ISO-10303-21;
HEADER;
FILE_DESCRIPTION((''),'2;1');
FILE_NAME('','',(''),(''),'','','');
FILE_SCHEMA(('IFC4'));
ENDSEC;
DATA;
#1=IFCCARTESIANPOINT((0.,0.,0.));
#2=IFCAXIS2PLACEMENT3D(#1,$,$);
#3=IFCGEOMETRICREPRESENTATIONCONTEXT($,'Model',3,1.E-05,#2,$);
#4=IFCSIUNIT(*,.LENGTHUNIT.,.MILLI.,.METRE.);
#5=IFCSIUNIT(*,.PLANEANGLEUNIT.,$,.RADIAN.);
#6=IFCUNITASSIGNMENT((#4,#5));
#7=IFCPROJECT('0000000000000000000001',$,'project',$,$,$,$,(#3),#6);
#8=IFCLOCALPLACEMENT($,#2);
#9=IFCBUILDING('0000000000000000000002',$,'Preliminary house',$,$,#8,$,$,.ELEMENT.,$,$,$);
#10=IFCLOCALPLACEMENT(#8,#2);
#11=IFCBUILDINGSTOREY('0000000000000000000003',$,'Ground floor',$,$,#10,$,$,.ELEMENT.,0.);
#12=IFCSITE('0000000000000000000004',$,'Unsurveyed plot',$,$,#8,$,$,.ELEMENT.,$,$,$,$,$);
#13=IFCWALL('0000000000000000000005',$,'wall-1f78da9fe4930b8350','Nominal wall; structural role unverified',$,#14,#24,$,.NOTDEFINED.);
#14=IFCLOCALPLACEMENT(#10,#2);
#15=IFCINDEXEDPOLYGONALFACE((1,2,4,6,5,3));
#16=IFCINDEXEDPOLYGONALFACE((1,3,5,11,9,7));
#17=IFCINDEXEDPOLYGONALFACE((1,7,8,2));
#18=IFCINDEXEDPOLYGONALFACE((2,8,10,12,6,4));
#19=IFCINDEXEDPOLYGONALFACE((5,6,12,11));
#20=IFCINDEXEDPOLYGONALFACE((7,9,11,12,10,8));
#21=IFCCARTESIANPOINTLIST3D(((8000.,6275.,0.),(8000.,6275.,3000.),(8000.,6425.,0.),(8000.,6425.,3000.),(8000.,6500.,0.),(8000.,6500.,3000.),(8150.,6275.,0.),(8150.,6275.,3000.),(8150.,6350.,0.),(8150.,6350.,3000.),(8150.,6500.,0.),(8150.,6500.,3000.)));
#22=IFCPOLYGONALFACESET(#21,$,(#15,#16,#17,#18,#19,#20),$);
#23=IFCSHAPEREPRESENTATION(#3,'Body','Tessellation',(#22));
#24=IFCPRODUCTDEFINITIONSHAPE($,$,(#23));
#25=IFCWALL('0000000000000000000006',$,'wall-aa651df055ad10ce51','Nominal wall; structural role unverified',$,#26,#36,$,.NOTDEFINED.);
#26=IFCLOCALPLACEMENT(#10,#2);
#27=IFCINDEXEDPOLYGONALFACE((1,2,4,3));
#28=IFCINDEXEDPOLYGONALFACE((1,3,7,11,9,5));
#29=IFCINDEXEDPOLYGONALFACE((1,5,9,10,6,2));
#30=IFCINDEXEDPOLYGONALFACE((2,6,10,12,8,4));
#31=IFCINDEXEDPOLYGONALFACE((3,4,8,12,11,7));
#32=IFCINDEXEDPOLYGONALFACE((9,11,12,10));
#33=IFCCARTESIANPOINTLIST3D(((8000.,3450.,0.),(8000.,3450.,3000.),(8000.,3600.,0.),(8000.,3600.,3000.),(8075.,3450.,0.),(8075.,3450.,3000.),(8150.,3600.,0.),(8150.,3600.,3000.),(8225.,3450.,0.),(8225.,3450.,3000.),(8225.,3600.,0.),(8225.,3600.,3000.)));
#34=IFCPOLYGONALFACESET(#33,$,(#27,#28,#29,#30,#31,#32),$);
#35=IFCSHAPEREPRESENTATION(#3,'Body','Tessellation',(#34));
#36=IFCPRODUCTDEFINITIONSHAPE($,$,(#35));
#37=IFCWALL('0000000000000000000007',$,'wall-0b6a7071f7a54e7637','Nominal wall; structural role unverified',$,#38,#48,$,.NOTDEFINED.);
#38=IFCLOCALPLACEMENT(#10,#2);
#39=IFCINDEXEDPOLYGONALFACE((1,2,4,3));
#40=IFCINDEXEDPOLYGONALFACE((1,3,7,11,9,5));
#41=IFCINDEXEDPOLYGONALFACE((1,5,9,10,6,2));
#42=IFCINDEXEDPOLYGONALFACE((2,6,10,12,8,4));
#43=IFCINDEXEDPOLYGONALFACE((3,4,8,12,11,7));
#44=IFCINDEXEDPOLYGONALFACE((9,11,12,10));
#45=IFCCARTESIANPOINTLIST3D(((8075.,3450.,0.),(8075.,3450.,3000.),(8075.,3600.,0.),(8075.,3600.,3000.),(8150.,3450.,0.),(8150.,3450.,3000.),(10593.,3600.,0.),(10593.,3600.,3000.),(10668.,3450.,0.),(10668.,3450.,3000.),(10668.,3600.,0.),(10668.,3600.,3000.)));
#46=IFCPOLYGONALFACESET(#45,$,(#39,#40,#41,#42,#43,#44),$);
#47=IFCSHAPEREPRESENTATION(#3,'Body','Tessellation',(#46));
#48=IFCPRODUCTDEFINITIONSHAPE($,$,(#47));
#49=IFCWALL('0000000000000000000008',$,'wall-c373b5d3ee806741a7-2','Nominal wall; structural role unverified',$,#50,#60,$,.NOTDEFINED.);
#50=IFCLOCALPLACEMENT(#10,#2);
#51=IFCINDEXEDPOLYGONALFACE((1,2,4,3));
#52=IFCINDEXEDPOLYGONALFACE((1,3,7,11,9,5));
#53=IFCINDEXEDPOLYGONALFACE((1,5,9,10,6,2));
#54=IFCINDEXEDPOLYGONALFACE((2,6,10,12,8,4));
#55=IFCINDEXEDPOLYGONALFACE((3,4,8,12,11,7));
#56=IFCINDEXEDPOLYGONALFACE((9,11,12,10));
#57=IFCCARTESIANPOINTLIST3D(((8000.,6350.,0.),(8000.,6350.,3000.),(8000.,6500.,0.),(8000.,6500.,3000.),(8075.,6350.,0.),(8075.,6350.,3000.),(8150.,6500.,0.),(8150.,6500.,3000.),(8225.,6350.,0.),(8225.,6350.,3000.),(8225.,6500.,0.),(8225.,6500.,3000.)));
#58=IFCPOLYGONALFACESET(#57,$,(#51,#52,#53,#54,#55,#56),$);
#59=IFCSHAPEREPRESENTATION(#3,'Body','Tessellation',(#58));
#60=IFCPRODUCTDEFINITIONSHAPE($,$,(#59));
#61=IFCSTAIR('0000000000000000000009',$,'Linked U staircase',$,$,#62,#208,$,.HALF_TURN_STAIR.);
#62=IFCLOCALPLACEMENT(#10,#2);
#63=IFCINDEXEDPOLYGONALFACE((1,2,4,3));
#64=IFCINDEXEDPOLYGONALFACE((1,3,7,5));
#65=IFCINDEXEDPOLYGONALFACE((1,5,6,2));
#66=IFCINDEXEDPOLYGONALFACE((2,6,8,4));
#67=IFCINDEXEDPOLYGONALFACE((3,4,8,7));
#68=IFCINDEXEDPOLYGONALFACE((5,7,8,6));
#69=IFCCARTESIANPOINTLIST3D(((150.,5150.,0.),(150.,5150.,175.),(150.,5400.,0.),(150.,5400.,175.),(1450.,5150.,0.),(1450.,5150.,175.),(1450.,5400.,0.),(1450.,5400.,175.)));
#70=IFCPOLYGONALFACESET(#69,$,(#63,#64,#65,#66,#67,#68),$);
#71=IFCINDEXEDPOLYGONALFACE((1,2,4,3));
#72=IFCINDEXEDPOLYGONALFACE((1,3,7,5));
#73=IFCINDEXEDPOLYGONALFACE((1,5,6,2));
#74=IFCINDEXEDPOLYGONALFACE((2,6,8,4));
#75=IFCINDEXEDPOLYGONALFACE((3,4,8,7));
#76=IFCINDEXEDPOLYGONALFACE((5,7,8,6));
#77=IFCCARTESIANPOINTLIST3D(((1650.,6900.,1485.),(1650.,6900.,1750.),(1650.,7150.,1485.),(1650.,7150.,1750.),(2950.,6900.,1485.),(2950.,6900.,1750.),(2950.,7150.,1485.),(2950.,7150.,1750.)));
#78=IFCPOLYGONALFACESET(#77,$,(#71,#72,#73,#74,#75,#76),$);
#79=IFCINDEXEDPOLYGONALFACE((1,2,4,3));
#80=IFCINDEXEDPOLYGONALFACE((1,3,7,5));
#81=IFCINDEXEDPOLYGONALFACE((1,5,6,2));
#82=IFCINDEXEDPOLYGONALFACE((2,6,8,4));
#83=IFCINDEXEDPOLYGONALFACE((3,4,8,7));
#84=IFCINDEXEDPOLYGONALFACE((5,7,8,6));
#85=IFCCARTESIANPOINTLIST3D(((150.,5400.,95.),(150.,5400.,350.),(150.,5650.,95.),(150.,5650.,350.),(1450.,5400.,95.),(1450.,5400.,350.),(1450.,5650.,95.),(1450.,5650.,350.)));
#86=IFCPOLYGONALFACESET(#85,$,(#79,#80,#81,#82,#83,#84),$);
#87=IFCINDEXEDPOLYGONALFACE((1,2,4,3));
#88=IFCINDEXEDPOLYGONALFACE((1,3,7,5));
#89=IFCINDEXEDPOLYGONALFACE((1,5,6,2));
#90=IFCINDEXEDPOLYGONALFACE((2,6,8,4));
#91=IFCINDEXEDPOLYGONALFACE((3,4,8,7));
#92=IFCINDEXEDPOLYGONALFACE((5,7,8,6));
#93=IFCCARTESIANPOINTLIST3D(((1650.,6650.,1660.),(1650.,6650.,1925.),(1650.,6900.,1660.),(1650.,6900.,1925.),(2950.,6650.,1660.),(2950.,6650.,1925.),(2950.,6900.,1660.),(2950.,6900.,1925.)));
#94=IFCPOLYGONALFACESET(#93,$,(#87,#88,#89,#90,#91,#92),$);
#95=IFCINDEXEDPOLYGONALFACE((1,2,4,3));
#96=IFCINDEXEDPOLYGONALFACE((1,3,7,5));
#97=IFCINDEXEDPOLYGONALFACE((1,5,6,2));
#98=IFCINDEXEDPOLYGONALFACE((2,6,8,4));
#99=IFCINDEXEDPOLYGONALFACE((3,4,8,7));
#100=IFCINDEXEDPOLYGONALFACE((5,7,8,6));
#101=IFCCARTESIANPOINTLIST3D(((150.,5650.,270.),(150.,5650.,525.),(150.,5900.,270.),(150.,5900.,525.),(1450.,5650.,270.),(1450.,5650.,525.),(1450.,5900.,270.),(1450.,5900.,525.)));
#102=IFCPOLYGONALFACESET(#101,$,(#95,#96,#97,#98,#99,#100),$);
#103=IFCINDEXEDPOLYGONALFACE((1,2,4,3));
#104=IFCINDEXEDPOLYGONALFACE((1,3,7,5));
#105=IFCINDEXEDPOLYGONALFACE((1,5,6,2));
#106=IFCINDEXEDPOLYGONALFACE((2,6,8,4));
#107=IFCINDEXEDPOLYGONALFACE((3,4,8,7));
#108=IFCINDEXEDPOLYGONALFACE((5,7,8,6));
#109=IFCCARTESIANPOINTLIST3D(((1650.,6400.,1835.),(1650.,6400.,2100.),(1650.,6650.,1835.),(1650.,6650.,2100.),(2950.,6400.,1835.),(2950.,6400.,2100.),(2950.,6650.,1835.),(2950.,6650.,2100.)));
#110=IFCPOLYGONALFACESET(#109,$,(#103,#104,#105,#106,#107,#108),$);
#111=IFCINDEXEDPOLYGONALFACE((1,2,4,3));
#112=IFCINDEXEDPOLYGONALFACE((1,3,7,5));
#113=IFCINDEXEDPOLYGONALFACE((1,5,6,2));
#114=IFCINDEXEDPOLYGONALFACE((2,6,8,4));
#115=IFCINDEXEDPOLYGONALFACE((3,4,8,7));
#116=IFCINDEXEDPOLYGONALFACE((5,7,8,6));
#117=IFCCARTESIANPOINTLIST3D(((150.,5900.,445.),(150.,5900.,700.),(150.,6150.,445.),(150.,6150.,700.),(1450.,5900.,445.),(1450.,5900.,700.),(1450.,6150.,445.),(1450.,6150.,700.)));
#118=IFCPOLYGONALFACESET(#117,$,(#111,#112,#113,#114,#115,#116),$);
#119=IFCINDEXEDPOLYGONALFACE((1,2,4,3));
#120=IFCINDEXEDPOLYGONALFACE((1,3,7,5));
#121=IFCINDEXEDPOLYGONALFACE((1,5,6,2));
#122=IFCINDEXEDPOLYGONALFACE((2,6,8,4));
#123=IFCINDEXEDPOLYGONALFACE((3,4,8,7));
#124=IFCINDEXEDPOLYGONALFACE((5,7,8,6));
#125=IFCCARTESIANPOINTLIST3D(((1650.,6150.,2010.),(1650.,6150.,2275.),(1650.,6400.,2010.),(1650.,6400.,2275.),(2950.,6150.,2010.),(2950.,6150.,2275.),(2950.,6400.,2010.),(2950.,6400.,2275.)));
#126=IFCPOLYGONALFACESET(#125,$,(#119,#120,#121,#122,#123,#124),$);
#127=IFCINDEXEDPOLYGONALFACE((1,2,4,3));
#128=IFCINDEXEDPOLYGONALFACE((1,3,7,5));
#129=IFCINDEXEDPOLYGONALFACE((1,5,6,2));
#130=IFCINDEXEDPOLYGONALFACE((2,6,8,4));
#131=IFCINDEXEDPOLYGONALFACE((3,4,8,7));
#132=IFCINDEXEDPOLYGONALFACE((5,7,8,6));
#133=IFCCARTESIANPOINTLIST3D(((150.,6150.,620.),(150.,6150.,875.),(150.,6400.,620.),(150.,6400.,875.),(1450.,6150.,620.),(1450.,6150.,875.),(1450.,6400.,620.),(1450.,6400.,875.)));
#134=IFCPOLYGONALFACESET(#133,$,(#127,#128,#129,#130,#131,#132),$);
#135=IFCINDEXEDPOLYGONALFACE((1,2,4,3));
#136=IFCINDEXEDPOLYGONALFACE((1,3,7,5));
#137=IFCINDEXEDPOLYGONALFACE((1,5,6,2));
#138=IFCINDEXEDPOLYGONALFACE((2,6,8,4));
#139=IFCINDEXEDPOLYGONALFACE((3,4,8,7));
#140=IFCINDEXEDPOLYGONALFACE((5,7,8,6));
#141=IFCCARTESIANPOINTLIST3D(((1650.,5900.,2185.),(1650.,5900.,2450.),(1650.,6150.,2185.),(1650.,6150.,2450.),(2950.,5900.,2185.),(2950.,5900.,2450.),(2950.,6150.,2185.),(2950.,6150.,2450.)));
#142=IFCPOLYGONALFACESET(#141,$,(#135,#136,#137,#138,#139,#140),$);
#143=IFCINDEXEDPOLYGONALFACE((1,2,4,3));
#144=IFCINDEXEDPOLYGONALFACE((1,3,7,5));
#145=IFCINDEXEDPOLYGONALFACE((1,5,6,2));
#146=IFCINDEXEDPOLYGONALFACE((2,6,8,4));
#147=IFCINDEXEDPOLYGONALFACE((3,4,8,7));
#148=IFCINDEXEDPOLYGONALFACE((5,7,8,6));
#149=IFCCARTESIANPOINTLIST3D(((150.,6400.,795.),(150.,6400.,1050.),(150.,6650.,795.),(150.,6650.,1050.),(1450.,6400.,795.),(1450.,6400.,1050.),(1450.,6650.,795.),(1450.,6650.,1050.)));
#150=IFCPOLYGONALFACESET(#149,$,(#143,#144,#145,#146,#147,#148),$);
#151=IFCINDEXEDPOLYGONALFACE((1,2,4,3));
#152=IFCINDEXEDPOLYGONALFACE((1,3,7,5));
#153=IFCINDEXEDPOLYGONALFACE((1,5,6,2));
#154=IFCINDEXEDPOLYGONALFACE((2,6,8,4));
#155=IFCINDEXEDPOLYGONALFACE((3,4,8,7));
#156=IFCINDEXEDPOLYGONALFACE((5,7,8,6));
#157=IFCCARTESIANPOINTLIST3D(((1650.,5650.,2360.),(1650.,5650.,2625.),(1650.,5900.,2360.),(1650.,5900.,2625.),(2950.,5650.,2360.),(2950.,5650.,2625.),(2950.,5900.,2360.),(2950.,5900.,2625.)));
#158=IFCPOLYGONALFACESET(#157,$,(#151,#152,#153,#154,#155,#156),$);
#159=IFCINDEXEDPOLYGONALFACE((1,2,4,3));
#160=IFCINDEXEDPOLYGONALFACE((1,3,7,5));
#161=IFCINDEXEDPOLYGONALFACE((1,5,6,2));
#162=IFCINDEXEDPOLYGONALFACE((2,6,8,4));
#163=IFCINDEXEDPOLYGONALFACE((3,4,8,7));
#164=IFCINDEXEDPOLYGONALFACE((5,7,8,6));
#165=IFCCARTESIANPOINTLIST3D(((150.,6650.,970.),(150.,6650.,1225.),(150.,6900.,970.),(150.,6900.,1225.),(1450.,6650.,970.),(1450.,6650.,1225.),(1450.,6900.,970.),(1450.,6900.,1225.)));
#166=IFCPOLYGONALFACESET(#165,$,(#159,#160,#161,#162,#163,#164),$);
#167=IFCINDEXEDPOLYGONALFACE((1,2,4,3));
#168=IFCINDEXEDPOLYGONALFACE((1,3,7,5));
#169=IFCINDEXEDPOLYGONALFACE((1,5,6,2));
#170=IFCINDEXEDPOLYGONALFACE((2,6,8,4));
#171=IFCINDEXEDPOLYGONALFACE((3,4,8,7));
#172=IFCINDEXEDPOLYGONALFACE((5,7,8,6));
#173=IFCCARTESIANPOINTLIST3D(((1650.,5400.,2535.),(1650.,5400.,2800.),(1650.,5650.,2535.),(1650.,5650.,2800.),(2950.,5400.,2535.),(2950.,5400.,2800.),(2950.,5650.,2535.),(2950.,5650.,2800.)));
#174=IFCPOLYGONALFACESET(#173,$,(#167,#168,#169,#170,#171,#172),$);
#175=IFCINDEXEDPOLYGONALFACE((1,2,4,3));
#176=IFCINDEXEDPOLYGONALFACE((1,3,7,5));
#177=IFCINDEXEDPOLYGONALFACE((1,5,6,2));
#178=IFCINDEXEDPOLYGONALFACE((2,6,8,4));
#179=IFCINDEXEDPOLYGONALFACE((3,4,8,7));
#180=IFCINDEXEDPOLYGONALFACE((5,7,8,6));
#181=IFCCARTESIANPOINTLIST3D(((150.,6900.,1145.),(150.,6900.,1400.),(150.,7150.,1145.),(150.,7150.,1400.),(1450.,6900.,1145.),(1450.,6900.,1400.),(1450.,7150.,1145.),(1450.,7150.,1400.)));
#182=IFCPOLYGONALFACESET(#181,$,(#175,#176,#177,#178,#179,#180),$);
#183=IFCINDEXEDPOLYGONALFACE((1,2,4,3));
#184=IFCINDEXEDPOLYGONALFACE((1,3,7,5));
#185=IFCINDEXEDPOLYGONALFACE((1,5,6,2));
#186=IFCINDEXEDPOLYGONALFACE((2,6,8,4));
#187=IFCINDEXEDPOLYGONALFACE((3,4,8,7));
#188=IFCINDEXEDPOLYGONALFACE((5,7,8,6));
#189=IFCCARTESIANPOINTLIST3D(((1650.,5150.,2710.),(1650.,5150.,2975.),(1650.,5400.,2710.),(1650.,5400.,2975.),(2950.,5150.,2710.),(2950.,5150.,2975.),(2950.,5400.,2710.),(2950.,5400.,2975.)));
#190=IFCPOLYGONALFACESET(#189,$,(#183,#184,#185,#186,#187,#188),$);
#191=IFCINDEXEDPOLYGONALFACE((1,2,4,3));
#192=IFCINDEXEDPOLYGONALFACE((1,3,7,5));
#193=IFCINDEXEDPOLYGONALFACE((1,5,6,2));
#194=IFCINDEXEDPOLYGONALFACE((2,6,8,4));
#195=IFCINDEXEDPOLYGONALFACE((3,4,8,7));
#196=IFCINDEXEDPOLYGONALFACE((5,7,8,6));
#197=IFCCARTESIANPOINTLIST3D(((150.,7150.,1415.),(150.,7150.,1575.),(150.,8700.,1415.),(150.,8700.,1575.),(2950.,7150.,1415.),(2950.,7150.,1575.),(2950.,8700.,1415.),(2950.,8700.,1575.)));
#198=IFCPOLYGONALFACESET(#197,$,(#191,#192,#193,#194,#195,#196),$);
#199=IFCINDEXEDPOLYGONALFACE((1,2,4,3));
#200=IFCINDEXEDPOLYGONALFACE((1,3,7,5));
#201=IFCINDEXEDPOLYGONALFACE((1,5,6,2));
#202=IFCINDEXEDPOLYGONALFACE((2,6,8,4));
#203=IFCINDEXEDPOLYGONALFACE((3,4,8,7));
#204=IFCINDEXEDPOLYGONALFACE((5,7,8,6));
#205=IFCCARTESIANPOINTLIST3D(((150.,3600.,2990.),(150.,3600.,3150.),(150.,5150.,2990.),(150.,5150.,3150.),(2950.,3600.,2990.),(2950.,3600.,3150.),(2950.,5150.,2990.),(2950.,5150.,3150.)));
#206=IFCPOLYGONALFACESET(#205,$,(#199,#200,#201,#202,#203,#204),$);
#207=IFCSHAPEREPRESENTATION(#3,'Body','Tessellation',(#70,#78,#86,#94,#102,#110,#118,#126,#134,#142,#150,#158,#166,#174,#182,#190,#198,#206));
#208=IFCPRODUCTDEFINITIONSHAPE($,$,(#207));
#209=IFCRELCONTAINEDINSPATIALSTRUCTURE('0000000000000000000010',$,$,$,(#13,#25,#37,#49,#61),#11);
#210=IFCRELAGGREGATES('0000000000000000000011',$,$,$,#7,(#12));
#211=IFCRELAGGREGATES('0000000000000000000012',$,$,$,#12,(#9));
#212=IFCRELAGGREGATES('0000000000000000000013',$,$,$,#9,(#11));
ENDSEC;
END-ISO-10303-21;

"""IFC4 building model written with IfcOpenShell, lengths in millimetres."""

from ifc_helpers import new_model, si_unit, frame, origin, place, context, project, spatial, polyline, outline, extrude, element, save


model = new_model("IFC4")

# Units and contexts
model_context = context("Model", 3, precision=1e-05, world=origin())
ifc_project = project(units=[si_unit("LENGTHUNIT", "METRE", prefix="MILLI"), si_unit("PLANEANGLEUNIT", "RADIAN")], contexts=[model_context])

# Site, building, storey
placement_1 = place(None, origin())
site = spatial("IfcSite", under=ifc_project, at=placement_1, Name="Unsurveyed plot", CompositionType="ELEMENT")
building = spatial("IfcBuilding", under=site, at=placement_1, Name="Preliminary house", CompositionType="ELEMENT")
placement_2 = place(placement_1, origin())
storey = spatial("IfcBuildingStorey", under=building, at=placement_2, Name="Ground floor", CompositionType="ELEMENT", Elevation=0.0)

# Walls
element("IfcWall", 1, at=placement_2, inside=storey, Name="wall-1f78da9fe4930b8350", Description="Nominal wall; structural role unverified", PredefinedType="NOTDEFINED", context=model_context, shape_type="SweptSolid", body=[
    extrude(outline(polyline([(8000.0, 6425.0), (8000.0, 6500.0), (8150.0, 6500.0), (8150.0, 6350.0), (8150.0, 6275.0), (8000.0, 6275.0), (8000.0, 6425.0)])), origin(), (0.0, 0.0, 1.0), 3000.0),
])
element("IfcWall", 2, at=placement_2, inside=storey, Name="wall-aa651df055ad10ce51", Description="Nominal wall; structural role unverified", PredefinedType="NOTDEFINED", context=model_context, shape_type="SweptSolid", body=[
    extrude(outline(polyline([(8150.0, 3600.0), (8225.0, 3600.0), (8225.0, 3450.0), (8075.0, 3450.0), (8000.0, 3450.0), (8000.0, 3600.0), (8150.0, 3600.0)])), origin(), (0.0, 0.0, 1.0), 3000.0),
])
element("IfcWall", 3, at=placement_2, inside=storey, Name="wall-0b6a7071f7a54e7637", Description="Nominal wall; structural role unverified", PredefinedType="NOTDEFINED", context=model_context, shape_type="SweptSolid", body=[
    extrude(outline(polyline([(10593.0, 3600.0), (10668.0, 3600.0), (10668.0, 3450.0), (8150.0, 3450.0), (8075.0, 3450.0), (8075.0, 3600.0), (10593.0, 3600.0)])), origin(), (0.0, 0.0, 1.0), 3000.0),
])
element("IfcWall", 4, at=placement_2, inside=storey, Name="wall-c373b5d3ee806741a7-2", Description="Nominal wall; structural role unverified", PredefinedType="NOTDEFINED", context=model_context, shape_type="SweptSolid", body=[
    extrude(outline(polyline([(8150.0, 6500.0), (8225.0, 6500.0), (8225.0, 6350.0), (8075.0, 6350.0), (8000.0, 6350.0), (8000.0, 6500.0), (8150.0, 6500.0)])), origin(), (0.0, 0.0, 1.0), 3000.0),
])

# Stair
element("IfcStair", 5, at=placement_2, inside=storey, Name="Linked U staircase", PredefinedType="HALF_TURN_STAIR", context=model_context, shape_type="SweptSolid", body=[
    extrude(outline(polyline([(1450.0, 5150.0), (1450.0, 5400.0), (150.0, 5400.0), (150.0, 5150.0), (1450.0, 5150.0)])), origin(), (0.0, 0.0, 1.0), 175.0),
    extrude(outline(polyline([(2950.0, 6900.0), (2950.0, 7150.0), (1650.0, 7150.0), (1650.0, 6900.0), (2950.0, 6900.0)])), frame((0.0, 0.0, 1485.0)), (0.0, 0.0, 1.0), 265.0),
    extrude(outline(polyline([(1450.0, 5400.0), (1450.0, 5650.0), (150.0, 5650.0), (150.0, 5400.0), (1450.0, 5400.0)])), frame((0.0, 0.0, 95.0)), (0.0, 0.0, 1.0), 255.0),
    extrude(outline(polyline([(2950.0, 6650.0), (2950.0, 6900.0), (1650.0, 6900.0), (1650.0, 6650.0), (2950.0, 6650.0)])), frame((0.0, 0.0, 1660.0)), (0.0, 0.0, 1.0), 265.0),
    extrude(outline(polyline([(1450.0, 5650.0), (1450.0, 5900.0), (150.0, 5900.0), (150.0, 5650.0), (1450.0, 5650.0)])), frame((0.0, 0.0, 270.0)), (0.0, 0.0, 1.0), 255.0),
    extrude(outline(polyline([(2950.0, 6400.0), (2950.0, 6650.0), (1650.0, 6650.0), (1650.0, 6400.0), (2950.0, 6400.0)])), frame((0.0, 0.0, 1835.0)), (0.0, 0.0, 1.0), 265.0),
    extrude(outline(polyline([(1450.0, 5900.0), (1450.0, 6150.0), (150.0, 6150.0), (150.0, 5900.0), (1450.0, 5900.0)])), frame((0.0, 0.0, 445.0)), (0.0, 0.0, 1.0), 255.0),
    extrude(outline(polyline([(2950.0, 6150.0), (2950.0, 6400.0), (1650.0, 6400.0), (1650.0, 6150.0), (2950.0, 6150.0)])), frame((0.0, 0.0, 2010.0)), (0.0, 0.0, 1.0), 265.0),
    extrude(outline(polyline([(1450.0, 6150.0), (1450.0, 6400.0), (150.0, 6400.0), (150.0, 6150.0), (1450.0, 6150.0)])), frame((0.0, 0.0, 620.0)), (0.0, 0.0, 1.0), 255.0),
    extrude(outline(polyline([(2950.0, 5900.0), (2950.0, 6150.0), (1650.0, 6150.0), (1650.0, 5900.0), (2950.0, 5900.0)])), frame((0.0, 0.0, 2185.0)), (0.0, 0.0, 1.0), 265.0),
    extrude(outline(polyline([(1450.0, 6400.0), (1450.0, 6650.0), (150.0, 6650.0), (150.0, 6400.0), (1450.0, 6400.0)])), frame((0.0, 0.0, 795.0)), (0.0, 0.0, 1.0), 255.0),
    extrude(outline(polyline([(2950.0, 5650.0), (2950.0, 5900.0), (1650.0, 5900.0), (1650.0, 5650.0), (2950.0, 5650.0)])), frame((0.0, 0.0, 2360.0)), (0.0, 0.0, 1.0), 265.0),
    extrude(outline(polyline([(1450.0, 6650.0), (1450.0, 6900.0), (150.0, 6900.0), (150.0, 6650.0), (1450.0, 6650.0)])), frame((0.0, 0.0, 970.0)), (0.0, 0.0, 1.0), 255.0),
    extrude(outline(polyline([(2950.0, 5400.0), (2950.0, 5650.0), (1650.0, 5650.0), (1650.0, 5400.0), (2950.0, 5400.0)])), frame((0.0, 0.0, 2535.0)), (0.0, 0.0, 1.0), 265.0),
    extrude(outline(polyline([(1450.0, 6900.0), (1450.0, 7150.0), (150.0, 7150.0), (150.0, 6900.0), (1450.0, 6900.0)])), frame((0.0, 0.0, 1145.0)), (0.0, 0.0, 1.0), 255.0),
    extrude(outline(polyline([(2950.0, 5150.0), (2950.0, 5400.0), (1650.0, 5400.0), (1650.0, 5150.0), (2950.0, 5150.0)])), frame((0.0, 0.0, 2710.0)), (0.0, 0.0, 1.0), 265.0),
    extrude(outline(polyline([(2950.0, 7150.0), (2950.0, 8700.0), (150.0, 8700.0), (150.0, 7150.0), (2950.0, 7150.0)])), frame((0.0, 0.0, 1415.0)), (0.0, 0.0, 1.0), 160.0),
    extrude(outline(polyline([(2950.0, 3600.0), (2950.0, 5150.0), (150.0, 5150.0), (150.0, 3600.0), (2950.0, 3600.0)])), frame((0.0, 0.0, 2990.0)), (0.0, 0.0, 1.0), 160.0),
])

save(model, "model.ifc")
